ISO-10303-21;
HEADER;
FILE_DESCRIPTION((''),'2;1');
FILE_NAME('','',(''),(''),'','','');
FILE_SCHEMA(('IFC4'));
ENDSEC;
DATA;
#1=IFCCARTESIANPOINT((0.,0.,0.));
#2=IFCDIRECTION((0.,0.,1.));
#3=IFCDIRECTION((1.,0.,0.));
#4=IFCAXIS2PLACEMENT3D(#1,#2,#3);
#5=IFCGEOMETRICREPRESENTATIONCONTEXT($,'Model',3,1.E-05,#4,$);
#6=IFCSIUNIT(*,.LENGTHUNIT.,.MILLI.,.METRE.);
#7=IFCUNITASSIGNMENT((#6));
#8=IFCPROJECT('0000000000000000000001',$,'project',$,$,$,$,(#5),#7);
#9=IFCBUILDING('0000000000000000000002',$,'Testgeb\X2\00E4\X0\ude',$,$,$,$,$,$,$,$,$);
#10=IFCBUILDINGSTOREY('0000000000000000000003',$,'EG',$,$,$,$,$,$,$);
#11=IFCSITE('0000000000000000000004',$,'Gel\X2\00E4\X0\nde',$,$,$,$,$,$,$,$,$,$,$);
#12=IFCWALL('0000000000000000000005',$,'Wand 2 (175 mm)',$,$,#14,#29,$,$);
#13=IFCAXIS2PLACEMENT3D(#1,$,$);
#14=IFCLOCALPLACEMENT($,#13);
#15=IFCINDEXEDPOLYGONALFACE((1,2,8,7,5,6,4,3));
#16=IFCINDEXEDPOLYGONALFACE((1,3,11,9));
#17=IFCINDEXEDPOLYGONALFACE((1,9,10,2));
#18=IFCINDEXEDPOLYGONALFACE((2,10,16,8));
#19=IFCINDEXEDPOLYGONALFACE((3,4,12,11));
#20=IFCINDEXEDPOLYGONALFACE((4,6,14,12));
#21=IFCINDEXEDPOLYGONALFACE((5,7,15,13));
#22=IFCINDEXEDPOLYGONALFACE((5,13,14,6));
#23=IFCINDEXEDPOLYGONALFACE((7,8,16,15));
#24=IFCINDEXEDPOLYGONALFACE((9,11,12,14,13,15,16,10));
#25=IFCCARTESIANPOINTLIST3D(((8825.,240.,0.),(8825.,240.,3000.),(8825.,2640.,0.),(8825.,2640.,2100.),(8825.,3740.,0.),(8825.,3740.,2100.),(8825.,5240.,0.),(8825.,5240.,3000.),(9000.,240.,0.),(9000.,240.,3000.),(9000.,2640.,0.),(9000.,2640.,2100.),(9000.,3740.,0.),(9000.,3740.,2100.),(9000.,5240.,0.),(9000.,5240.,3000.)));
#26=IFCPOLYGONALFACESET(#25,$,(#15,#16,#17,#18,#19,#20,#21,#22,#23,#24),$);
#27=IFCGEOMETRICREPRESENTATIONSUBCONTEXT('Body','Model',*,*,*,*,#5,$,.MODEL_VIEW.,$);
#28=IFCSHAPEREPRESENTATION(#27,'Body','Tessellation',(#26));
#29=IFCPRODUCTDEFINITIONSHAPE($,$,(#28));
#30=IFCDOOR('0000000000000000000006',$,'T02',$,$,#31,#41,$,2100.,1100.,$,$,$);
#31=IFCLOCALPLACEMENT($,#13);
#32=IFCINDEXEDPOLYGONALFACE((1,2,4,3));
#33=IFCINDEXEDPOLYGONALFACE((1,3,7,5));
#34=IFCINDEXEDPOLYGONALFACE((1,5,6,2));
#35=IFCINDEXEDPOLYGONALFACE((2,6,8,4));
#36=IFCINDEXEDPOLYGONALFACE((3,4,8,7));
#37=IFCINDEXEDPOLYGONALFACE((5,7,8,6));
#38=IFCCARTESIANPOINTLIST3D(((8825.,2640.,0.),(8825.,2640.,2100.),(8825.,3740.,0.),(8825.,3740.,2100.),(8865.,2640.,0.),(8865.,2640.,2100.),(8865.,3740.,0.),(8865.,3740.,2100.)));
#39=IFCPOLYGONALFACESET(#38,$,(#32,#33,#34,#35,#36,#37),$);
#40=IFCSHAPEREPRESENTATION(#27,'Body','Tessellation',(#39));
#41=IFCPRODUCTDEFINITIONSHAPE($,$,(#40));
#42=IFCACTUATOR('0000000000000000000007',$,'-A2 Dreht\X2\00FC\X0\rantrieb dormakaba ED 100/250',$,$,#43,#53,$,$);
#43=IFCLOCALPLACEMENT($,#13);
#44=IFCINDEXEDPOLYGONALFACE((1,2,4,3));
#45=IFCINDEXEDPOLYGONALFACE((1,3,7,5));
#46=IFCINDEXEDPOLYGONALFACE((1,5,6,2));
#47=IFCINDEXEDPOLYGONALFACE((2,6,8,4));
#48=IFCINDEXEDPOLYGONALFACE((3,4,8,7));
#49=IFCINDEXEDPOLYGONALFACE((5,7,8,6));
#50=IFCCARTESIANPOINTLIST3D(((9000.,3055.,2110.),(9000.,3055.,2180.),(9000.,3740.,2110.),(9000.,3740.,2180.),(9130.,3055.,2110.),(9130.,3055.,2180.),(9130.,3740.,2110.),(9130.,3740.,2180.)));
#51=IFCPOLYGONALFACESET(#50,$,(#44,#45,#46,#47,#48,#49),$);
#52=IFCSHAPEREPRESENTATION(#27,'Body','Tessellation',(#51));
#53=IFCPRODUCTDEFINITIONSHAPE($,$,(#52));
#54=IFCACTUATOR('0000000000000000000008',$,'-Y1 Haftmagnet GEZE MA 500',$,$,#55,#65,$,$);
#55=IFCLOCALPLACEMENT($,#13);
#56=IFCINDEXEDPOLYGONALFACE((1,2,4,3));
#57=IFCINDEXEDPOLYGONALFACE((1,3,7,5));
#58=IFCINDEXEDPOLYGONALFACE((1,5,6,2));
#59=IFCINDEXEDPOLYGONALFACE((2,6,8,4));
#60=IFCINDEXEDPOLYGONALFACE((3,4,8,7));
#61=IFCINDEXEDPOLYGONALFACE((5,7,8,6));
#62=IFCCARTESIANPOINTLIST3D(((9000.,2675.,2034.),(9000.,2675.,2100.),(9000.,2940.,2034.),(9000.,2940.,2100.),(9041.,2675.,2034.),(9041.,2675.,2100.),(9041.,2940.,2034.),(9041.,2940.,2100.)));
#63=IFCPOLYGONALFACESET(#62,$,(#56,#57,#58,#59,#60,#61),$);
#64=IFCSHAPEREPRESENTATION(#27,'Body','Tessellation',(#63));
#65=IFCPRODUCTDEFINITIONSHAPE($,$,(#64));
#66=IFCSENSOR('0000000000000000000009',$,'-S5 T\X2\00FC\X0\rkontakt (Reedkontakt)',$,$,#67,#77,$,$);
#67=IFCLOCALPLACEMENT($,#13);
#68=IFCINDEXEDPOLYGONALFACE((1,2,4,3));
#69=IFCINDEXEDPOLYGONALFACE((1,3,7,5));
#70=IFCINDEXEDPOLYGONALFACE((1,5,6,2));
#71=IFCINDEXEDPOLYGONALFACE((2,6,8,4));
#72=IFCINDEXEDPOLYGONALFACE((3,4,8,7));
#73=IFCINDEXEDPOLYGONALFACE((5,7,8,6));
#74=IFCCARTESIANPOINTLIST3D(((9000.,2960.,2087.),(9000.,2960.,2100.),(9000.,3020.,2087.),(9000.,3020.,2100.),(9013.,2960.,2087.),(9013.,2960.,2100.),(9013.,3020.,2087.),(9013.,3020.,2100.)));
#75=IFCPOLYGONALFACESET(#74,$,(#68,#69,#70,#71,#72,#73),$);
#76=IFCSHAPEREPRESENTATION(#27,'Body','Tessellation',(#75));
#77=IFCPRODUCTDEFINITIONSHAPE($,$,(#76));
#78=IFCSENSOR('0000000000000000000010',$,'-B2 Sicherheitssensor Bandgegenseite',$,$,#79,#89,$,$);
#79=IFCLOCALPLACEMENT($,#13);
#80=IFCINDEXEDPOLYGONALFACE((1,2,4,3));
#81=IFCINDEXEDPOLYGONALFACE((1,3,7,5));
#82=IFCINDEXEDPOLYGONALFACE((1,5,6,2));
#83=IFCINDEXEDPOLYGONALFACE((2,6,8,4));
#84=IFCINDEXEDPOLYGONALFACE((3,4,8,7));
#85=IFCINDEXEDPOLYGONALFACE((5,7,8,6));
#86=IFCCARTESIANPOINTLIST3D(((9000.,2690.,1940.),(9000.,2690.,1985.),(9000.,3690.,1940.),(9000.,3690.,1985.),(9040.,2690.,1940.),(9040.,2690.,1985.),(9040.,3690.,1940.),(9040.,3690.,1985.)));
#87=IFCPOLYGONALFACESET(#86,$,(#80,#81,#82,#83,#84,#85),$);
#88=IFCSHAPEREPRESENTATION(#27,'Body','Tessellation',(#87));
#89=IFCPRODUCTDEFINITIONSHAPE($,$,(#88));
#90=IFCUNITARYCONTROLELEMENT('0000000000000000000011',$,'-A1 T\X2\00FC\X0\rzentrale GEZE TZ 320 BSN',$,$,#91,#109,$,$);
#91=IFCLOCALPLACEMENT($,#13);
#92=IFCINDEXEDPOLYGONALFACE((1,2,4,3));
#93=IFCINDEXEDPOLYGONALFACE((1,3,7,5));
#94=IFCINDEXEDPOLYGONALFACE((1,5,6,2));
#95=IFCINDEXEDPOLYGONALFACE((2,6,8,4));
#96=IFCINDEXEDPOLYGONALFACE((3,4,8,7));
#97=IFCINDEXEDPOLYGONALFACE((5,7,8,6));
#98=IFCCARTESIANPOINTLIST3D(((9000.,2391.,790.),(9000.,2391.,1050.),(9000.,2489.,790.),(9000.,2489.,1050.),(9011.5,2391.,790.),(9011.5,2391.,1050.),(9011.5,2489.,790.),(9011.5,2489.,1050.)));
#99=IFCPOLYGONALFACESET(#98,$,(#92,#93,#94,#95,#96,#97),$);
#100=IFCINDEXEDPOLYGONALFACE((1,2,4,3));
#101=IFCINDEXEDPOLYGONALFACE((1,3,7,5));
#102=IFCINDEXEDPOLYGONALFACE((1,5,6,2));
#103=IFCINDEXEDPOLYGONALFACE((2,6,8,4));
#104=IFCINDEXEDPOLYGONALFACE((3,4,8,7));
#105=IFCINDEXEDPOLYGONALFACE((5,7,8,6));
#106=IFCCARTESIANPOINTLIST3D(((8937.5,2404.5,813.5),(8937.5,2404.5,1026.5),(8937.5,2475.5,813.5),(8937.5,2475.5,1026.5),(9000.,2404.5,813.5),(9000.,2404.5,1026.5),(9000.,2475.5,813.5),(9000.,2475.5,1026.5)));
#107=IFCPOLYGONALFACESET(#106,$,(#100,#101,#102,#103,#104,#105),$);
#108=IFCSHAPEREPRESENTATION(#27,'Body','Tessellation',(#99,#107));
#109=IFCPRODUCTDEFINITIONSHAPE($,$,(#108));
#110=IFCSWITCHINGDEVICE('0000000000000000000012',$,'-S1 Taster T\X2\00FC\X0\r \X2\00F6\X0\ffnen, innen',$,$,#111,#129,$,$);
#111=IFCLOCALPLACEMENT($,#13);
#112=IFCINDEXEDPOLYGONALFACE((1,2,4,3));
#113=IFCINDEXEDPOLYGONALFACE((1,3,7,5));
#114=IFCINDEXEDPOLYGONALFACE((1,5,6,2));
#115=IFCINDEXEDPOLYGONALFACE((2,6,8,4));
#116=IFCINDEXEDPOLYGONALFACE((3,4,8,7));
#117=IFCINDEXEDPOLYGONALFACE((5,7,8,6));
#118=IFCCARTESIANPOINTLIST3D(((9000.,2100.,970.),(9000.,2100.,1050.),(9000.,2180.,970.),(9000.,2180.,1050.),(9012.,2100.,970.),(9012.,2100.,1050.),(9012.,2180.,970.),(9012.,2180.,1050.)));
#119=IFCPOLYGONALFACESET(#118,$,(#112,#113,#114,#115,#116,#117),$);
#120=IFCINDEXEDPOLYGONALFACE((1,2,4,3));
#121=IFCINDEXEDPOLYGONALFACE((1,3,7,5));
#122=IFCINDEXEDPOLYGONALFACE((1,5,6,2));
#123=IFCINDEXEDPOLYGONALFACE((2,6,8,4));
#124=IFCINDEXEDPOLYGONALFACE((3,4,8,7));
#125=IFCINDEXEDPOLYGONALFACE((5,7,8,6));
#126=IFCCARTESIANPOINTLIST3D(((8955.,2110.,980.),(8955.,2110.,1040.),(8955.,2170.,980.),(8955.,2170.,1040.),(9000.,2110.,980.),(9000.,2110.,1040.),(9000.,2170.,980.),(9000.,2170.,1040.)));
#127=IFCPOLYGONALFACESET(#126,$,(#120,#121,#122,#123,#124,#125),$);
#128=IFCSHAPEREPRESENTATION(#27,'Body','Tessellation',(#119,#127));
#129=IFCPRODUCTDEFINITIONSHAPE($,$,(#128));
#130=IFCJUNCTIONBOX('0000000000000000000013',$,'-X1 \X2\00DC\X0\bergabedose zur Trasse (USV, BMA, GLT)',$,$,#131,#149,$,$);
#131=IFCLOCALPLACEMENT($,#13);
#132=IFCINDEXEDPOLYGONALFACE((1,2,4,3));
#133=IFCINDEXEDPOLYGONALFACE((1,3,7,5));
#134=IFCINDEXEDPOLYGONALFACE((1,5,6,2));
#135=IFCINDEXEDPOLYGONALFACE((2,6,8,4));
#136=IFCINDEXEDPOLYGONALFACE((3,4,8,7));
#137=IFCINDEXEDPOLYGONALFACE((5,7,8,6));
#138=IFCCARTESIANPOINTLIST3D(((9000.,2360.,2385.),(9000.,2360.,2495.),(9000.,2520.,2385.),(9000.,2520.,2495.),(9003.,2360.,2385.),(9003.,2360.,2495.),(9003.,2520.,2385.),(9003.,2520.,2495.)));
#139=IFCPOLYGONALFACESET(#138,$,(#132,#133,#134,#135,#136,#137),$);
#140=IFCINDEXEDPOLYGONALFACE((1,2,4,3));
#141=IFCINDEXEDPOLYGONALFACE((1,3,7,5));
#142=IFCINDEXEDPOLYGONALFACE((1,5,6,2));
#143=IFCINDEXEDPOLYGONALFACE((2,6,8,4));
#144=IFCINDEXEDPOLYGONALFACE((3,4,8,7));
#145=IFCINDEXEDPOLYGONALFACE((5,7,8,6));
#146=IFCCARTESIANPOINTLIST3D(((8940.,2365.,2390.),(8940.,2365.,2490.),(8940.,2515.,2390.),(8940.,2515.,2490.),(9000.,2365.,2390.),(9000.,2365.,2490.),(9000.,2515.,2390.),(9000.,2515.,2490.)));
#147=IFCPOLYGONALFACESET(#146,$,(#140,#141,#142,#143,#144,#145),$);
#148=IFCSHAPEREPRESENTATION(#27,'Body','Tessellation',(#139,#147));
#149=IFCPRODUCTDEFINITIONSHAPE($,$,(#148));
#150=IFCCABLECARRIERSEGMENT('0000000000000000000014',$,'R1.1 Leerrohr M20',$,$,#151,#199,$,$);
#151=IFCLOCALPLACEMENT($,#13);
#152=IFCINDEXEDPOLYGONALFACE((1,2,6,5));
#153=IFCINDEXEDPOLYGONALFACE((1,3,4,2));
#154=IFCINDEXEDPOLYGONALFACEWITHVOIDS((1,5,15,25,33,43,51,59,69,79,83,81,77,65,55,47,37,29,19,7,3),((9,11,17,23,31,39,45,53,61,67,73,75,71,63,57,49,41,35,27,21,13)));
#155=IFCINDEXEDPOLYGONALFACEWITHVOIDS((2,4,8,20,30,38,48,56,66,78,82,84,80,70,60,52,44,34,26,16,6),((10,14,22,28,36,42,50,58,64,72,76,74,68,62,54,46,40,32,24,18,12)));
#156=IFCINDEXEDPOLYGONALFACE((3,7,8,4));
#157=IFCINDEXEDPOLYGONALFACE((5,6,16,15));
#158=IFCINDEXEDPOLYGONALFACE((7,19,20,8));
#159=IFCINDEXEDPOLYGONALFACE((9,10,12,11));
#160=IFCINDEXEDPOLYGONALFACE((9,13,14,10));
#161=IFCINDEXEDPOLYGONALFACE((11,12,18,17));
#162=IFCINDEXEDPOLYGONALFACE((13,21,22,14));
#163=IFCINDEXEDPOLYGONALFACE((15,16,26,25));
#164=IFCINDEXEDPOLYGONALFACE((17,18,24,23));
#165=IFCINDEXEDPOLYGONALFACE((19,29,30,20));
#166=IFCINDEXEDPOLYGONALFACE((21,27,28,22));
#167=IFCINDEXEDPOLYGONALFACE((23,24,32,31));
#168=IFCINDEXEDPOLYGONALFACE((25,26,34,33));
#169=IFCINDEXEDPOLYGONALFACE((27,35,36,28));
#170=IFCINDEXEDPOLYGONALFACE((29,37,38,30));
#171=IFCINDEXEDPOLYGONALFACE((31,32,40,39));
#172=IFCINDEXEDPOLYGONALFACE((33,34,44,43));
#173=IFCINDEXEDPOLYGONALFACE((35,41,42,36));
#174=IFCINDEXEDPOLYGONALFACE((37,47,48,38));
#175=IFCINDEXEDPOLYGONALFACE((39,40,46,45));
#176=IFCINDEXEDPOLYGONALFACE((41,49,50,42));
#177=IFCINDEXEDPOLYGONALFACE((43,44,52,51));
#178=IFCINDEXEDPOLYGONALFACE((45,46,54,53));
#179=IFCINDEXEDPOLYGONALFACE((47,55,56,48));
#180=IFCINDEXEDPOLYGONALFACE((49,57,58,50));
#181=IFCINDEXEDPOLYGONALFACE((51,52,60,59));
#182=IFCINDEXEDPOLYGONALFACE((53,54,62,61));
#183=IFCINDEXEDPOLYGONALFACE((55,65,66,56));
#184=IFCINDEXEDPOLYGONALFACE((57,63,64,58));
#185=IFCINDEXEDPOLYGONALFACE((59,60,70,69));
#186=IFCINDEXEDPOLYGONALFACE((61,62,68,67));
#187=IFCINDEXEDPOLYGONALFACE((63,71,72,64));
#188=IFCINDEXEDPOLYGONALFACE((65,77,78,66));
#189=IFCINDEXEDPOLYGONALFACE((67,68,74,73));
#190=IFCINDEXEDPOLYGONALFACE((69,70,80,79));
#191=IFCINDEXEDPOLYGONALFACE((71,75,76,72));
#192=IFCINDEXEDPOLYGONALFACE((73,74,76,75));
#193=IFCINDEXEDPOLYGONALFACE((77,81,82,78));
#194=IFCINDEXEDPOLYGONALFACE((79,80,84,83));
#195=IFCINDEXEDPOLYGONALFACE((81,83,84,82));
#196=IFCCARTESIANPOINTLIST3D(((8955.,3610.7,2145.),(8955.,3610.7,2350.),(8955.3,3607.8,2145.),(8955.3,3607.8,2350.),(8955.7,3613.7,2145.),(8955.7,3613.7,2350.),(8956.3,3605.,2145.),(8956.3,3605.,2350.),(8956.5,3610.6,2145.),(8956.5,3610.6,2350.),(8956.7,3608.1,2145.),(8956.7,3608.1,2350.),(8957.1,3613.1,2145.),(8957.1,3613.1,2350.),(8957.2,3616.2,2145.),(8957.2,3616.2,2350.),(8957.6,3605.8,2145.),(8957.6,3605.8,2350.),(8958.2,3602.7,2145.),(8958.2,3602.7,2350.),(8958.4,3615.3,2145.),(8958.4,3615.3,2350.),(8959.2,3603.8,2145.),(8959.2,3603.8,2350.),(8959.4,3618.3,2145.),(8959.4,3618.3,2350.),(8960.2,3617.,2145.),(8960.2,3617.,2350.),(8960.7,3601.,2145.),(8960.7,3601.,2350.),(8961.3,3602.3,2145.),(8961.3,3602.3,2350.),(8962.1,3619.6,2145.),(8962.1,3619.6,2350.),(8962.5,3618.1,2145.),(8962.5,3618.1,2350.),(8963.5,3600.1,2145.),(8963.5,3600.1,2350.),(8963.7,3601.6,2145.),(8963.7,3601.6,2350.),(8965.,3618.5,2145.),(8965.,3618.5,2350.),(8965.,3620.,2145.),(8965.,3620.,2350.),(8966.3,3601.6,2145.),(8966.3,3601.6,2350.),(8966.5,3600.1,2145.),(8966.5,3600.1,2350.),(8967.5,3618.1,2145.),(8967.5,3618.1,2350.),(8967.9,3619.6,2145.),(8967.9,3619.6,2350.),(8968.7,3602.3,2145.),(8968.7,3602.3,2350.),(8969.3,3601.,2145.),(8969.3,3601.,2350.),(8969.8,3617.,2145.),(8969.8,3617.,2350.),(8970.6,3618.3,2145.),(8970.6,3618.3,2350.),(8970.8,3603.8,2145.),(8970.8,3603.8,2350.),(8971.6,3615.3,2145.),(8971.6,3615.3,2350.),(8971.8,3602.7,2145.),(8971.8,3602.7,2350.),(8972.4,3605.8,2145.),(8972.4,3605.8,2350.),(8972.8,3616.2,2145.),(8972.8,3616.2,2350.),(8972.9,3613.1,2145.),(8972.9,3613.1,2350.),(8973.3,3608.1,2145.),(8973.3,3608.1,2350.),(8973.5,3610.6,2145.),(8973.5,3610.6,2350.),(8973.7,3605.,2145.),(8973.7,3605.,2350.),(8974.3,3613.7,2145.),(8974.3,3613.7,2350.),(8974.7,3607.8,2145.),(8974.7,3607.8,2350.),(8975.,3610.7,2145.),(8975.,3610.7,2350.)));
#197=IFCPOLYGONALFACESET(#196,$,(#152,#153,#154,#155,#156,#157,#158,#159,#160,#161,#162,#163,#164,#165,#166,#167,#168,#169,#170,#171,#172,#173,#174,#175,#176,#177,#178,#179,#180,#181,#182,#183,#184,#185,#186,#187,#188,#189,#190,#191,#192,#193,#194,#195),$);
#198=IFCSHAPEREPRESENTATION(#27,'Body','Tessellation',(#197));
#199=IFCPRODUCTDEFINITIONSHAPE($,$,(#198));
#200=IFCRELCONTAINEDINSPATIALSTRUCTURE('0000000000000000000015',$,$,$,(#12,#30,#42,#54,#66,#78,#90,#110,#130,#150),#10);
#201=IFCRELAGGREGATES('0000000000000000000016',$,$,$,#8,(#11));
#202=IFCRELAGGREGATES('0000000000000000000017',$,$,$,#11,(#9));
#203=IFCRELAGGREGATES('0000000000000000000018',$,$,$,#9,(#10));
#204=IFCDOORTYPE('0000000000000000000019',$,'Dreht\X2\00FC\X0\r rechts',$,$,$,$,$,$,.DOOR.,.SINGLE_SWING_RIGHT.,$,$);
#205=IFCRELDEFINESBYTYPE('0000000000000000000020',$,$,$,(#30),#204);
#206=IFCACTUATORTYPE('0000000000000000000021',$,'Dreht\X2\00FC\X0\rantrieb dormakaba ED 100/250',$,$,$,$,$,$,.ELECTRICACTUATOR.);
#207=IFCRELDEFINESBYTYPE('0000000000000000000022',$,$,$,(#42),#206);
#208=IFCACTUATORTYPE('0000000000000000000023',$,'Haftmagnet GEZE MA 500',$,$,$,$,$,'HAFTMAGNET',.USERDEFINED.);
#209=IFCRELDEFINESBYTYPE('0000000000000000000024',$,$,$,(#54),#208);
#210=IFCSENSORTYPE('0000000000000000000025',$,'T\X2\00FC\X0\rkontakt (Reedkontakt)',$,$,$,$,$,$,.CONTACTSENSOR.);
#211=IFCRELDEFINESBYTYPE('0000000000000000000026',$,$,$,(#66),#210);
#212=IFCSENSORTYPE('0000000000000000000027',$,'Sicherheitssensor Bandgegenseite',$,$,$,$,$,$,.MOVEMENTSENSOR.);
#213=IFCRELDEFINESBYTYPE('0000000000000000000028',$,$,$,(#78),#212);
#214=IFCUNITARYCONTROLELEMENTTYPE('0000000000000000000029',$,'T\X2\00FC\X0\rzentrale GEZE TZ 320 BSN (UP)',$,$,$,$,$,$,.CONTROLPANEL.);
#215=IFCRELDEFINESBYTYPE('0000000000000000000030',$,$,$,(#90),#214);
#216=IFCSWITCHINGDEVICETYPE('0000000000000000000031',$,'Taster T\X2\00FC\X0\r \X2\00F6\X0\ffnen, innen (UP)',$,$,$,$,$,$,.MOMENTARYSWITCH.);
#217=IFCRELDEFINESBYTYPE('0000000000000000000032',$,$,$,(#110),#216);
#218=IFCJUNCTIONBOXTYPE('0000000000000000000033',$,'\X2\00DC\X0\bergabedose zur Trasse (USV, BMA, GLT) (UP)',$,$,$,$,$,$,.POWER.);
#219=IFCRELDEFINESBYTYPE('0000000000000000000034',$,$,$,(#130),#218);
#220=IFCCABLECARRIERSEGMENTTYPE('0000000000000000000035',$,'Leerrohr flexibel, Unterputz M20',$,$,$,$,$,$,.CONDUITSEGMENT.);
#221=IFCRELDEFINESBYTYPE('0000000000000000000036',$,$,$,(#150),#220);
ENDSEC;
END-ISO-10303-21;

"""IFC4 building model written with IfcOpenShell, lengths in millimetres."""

from ifc_helpers import new_model, si_unit, frame, frame_2d, origin_with_axes, place, context, subcontext, project, spatial, rectangle, hollow_circle, extrude, type_object, element, fill, save


model = new_model("IFC4")

# Units and contexts
model_context = context("Model", 3, precision=1e-05, world=origin_with_axes())
body_context = subcontext(model_context, "Body", "Model", "MODEL_VIEW")
ifc_project = project(units=[si_unit("LENGTHUNIT", "METRE", prefix="MILLI")], contexts=[model_context])

# Site, building, storey
site = spatial("IfcSite", under=ifc_project, Name="Gelände")
building = spatial("IfcBuilding", under=site, Name="Testgebäude")
storey = spatial("IfcBuildingStorey", under=building, Name="EG")

# Wall, opening, door
wall_placement = place(None, frame((9000.0, 240.0, 0.0), z_axis=(0.0, 0.0, 1.0), x_axis=(0.0, 1.0, 0.0)))
wall = element("IfcWall", 1, at=wall_placement, inside=storey, Name="Wand 2 (175 mm)", context=body_context, shape_type="SweptSolid", body=[
    extrude(rectangle(XDim=5000.0, YDim=175.0, at=frame_2d((2500.0, 87.5))), None, (0.0, 0.0, 1.0), 3000.0),
])
opening_placement = place(None, frame((9000.0, 2640.0, 0.0), z_axis=(0.0, 0.0, 1.0), x_axis=(0.0, 1.0, 0.0)))
opening = element("IfcOpeningElement", 2, at=opening_placement, cuts=wall, context=body_context, shape_type="SweptSolid", body=[
    extrude(rectangle(XDim=1100.0, YDim=175.0, at=frame_2d((550.0, 87.5))), None, (0.0, 0.0, 1.0), 2100.0),
])
door_type = type_object("IfcDoorType", Name="Drehtür rechts", OperationType="SINGLE_SWING_RIGHT", PredefinedType="DOOR")
door_placement = place(opening_placement, origin_with_axes())
door = element("IfcDoor", 3, at=door_placement, inside=storey, type_object=door_type, Name="T02", OverallHeight=2100.0, OverallWidth=1100.0, context=body_context, shape_type="SweptSolid", body=[
    extrude(rectangle(XDim=1100.0, YDim=40.0, at=frame_2d((550.0, 20.0))), frame((0.0, 135.0, 0.0)), (0.0, 0.0, 1.0), 2100.0),
])
fill(opening, door)

# Actuators
actuator_type_1 = type_object("IfcActuatorType", Name="Drehtürantrieb dormakaba ED 100/250", PredefinedType="ELECTRICACTUATOR")
actuator_1_placement = place(None, frame((9130.0, 3055.0, 2110.0), z_axis=(0.0, 0.0, 1.0), x_axis=(0.0, 1.0, 0.0)))
element("IfcActuator", 4, at=actuator_1_placement, inside=storey, type_object=actuator_type_1, Name="-A2 Drehtürantrieb dormakaba ED 100/250", context=body_context, shape_type="SweptSolid", body=[
    extrude(rectangle(XDim=685.0, YDim=130.0, at=frame_2d((342.5, 65.0))), None, (0.0, 0.0, 1.0), 70.0),
])
actuator_type_2 = type_object("IfcActuatorType", Name="Haftmagnet GEZE MA 500", ElementType="HAFTMAGNET", PredefinedType="USERDEFINED")
actuator_2_placement = place(None, frame((9041.0, 2675.0, 2034.0), z_axis=(0.0, 0.0, 1.0), x_axis=(0.0, 1.0, 0.0)))
element("IfcActuator", 5, at=actuator_2_placement, inside=storey, type_object=actuator_type_2, Name="-Y1 Haftmagnet GEZE MA 500", context=body_context, shape_type="SweptSolid", body=[
    extrude(rectangle(XDim=265.0, YDim=41.0, at=frame_2d((132.5, 20.5))), None, (0.0, 0.0, 1.0), 66.0),
])

# Sensors
sensor_type_1 = type_object("IfcSensorType", Name="Türkontakt (Reedkontakt)", PredefinedType="CONTACTSENSOR")
sensor_1_placement = place(None, frame((9013.0, 2960.0, 2087.0), z_axis=(0.0, 0.0, 1.0), x_axis=(0.0, 1.0, 0.0)))
element("IfcSensor", 6, at=sensor_1_placement, inside=storey, type_object=sensor_type_1, Name="-S5 Türkontakt (Reedkontakt)", context=body_context, shape_type="SweptSolid", body=[
    extrude(rectangle(XDim=60.0, YDim=13.0, at=frame_2d((30.0, 6.5))), None, (0.0, 0.0, 1.0), 13.0),
])
sensor_type_2 = type_object("IfcSensorType", Name="Sicherheitssensor Bandgegenseite", PredefinedType="MOVEMENTSENSOR")
sensor_2_placement = place(None, frame((9040.0, 2690.0, 1940.0), z_axis=(0.0, 0.0, 1.0), x_axis=(0.0, 1.0, 0.0)))
element("IfcSensor", 7, at=sensor_2_placement, inside=storey, type_object=sensor_type_2, Name="-B2 Sicherheitssensor Bandgegenseite", context=body_context, shape_type="SweptSolid", body=[
    extrude(rectangle(XDim=1000.0, YDim=40.0, at=frame_2d((500.0, 20.0))), None, (0.0, 0.0, 1.0), 45.0),
])

# Unitary control element
unitary_control_element_type = type_object("IfcUnitaryControlElementType", Name="Türzentrale GEZE TZ 320 BSN (UP)", PredefinedType="CONTROLPANEL")
unitary_control_element_placement = place(None, frame((9011.5, 2391.0, 790.0), z_axis=(0.0, 0.0, 1.0), x_axis=(0.0, 1.0, 0.0)))
element("IfcUnitaryControlElement", 8, at=unitary_control_element_placement, inside=storey, type_object=unitary_control_element_type, Name="-A1 Türzentrale GEZE TZ 320 BSN", context=body_context, shape_type="SweptSolid", body=[
    extrude(rectangle(XDim=98.0, YDim=11.5, at=frame_2d((49.0, 5.8))), None, (0.0, 0.0, 1.0), 260.0),
    extrude(rectangle(XDim=71.0, YDim=62.5, at=frame_2d((35.5, 31.2))), frame((13.5, 11.5, 23.5), z_axis=(0.0, 0.0, 1.0), x_axis=(1.0, 0.0, 0.0)), (0.0, 0.0, 1.0), 213.0),
])

# Switching device
switching_device_type = type_object("IfcSwitchingDeviceType", Name="Taster Tür öffnen, innen (UP)", PredefinedType="MOMENTARYSWITCH")
switching_device_placement = place(None, frame((9012.0, 2100.0, 970.0), z_axis=(0.0, 0.0, 1.0), x_axis=(0.0, 1.0, 0.0)))
element("IfcSwitchingDevice", 9, at=switching_device_placement, inside=storey, type_object=switching_device_type, Name="-S1 Taster Tür öffnen, innen", context=body_context, shape_type="SweptSolid", body=[
    extrude(rectangle(XDim=80.0, YDim=12.0, at=frame_2d((40.0, 6.0))), None, (0.0, 0.0, 1.0), 80.0),
    extrude(rectangle(XDim=60.0, YDim=45.0, at=frame_2d((30.0, 22.5))), frame((10.0, 12.0, 10.0), z_axis=(0.0, 0.0, 1.0), x_axis=(1.0, 0.0, 0.0)), (0.0, 0.0, 1.0), 60.0),
])

# Junction box
junction_box_type = type_object("IfcJunctionBoxType", Name="Übergabedose zur Trasse (USV, BMA, GLT) (UP)", PredefinedType="POWER")
junction_box_placement = place(None, frame((9003.0, 2360.0, 2385.0), z_axis=(0.0, 0.0, 1.0), x_axis=(0.0, 1.0, 0.0)))
element("IfcJunctionBox", 10, at=junction_box_placement, inside=storey, type_object=junction_box_type, Name="-X1 Übergabedose zur Trasse (USV, BMA, GLT)", context=body_context, shape_type="SweptSolid", body=[
    extrude(rectangle(XDim=160.0, YDim=3.0, at=frame_2d((80.0, 1.5))), None, (0.0, 0.0, 1.0), 110.0),
    extrude(rectangle(XDim=150.0, YDim=60.0, at=frame_2d((75.0, 30.0))), frame((5.0, 3.0, 5.0), z_axis=(0.0, 0.0, 1.0), x_axis=(1.0, 0.0, 0.0)), (0.0, 0.0, 1.0), 100.0),
])

# Cable carrier segment
cable_carrier_segment_type_1 = type_object("IfcCableCarrierSegmentType", Name="Leerrohr flexibel, Unterputz M20", PredefinedType="CONDUITSEGMENT")
cable_carrier_segment_1_placement = place(None, frame((8965.0, 3610.0, 2145.0), z_axis=(0.0, 0.0, 1.0), x_axis=(0.0, 1.0, 0.0)))
element("IfcCableCarrierSegment", 11, at=cable_carrier_segment_1_placement, inside=storey, type_object=cable_carrier_segment_type_1, Name="R1.1 Leerrohr M20", context=body_context, shape_type="SweptSolid", body=[
    extrude(hollow_circle(Radius=10.0, WallThickness=1.5), None, (0.0, 0.0, 1.0), 205.0),
])

save(model, "model.ifc")
